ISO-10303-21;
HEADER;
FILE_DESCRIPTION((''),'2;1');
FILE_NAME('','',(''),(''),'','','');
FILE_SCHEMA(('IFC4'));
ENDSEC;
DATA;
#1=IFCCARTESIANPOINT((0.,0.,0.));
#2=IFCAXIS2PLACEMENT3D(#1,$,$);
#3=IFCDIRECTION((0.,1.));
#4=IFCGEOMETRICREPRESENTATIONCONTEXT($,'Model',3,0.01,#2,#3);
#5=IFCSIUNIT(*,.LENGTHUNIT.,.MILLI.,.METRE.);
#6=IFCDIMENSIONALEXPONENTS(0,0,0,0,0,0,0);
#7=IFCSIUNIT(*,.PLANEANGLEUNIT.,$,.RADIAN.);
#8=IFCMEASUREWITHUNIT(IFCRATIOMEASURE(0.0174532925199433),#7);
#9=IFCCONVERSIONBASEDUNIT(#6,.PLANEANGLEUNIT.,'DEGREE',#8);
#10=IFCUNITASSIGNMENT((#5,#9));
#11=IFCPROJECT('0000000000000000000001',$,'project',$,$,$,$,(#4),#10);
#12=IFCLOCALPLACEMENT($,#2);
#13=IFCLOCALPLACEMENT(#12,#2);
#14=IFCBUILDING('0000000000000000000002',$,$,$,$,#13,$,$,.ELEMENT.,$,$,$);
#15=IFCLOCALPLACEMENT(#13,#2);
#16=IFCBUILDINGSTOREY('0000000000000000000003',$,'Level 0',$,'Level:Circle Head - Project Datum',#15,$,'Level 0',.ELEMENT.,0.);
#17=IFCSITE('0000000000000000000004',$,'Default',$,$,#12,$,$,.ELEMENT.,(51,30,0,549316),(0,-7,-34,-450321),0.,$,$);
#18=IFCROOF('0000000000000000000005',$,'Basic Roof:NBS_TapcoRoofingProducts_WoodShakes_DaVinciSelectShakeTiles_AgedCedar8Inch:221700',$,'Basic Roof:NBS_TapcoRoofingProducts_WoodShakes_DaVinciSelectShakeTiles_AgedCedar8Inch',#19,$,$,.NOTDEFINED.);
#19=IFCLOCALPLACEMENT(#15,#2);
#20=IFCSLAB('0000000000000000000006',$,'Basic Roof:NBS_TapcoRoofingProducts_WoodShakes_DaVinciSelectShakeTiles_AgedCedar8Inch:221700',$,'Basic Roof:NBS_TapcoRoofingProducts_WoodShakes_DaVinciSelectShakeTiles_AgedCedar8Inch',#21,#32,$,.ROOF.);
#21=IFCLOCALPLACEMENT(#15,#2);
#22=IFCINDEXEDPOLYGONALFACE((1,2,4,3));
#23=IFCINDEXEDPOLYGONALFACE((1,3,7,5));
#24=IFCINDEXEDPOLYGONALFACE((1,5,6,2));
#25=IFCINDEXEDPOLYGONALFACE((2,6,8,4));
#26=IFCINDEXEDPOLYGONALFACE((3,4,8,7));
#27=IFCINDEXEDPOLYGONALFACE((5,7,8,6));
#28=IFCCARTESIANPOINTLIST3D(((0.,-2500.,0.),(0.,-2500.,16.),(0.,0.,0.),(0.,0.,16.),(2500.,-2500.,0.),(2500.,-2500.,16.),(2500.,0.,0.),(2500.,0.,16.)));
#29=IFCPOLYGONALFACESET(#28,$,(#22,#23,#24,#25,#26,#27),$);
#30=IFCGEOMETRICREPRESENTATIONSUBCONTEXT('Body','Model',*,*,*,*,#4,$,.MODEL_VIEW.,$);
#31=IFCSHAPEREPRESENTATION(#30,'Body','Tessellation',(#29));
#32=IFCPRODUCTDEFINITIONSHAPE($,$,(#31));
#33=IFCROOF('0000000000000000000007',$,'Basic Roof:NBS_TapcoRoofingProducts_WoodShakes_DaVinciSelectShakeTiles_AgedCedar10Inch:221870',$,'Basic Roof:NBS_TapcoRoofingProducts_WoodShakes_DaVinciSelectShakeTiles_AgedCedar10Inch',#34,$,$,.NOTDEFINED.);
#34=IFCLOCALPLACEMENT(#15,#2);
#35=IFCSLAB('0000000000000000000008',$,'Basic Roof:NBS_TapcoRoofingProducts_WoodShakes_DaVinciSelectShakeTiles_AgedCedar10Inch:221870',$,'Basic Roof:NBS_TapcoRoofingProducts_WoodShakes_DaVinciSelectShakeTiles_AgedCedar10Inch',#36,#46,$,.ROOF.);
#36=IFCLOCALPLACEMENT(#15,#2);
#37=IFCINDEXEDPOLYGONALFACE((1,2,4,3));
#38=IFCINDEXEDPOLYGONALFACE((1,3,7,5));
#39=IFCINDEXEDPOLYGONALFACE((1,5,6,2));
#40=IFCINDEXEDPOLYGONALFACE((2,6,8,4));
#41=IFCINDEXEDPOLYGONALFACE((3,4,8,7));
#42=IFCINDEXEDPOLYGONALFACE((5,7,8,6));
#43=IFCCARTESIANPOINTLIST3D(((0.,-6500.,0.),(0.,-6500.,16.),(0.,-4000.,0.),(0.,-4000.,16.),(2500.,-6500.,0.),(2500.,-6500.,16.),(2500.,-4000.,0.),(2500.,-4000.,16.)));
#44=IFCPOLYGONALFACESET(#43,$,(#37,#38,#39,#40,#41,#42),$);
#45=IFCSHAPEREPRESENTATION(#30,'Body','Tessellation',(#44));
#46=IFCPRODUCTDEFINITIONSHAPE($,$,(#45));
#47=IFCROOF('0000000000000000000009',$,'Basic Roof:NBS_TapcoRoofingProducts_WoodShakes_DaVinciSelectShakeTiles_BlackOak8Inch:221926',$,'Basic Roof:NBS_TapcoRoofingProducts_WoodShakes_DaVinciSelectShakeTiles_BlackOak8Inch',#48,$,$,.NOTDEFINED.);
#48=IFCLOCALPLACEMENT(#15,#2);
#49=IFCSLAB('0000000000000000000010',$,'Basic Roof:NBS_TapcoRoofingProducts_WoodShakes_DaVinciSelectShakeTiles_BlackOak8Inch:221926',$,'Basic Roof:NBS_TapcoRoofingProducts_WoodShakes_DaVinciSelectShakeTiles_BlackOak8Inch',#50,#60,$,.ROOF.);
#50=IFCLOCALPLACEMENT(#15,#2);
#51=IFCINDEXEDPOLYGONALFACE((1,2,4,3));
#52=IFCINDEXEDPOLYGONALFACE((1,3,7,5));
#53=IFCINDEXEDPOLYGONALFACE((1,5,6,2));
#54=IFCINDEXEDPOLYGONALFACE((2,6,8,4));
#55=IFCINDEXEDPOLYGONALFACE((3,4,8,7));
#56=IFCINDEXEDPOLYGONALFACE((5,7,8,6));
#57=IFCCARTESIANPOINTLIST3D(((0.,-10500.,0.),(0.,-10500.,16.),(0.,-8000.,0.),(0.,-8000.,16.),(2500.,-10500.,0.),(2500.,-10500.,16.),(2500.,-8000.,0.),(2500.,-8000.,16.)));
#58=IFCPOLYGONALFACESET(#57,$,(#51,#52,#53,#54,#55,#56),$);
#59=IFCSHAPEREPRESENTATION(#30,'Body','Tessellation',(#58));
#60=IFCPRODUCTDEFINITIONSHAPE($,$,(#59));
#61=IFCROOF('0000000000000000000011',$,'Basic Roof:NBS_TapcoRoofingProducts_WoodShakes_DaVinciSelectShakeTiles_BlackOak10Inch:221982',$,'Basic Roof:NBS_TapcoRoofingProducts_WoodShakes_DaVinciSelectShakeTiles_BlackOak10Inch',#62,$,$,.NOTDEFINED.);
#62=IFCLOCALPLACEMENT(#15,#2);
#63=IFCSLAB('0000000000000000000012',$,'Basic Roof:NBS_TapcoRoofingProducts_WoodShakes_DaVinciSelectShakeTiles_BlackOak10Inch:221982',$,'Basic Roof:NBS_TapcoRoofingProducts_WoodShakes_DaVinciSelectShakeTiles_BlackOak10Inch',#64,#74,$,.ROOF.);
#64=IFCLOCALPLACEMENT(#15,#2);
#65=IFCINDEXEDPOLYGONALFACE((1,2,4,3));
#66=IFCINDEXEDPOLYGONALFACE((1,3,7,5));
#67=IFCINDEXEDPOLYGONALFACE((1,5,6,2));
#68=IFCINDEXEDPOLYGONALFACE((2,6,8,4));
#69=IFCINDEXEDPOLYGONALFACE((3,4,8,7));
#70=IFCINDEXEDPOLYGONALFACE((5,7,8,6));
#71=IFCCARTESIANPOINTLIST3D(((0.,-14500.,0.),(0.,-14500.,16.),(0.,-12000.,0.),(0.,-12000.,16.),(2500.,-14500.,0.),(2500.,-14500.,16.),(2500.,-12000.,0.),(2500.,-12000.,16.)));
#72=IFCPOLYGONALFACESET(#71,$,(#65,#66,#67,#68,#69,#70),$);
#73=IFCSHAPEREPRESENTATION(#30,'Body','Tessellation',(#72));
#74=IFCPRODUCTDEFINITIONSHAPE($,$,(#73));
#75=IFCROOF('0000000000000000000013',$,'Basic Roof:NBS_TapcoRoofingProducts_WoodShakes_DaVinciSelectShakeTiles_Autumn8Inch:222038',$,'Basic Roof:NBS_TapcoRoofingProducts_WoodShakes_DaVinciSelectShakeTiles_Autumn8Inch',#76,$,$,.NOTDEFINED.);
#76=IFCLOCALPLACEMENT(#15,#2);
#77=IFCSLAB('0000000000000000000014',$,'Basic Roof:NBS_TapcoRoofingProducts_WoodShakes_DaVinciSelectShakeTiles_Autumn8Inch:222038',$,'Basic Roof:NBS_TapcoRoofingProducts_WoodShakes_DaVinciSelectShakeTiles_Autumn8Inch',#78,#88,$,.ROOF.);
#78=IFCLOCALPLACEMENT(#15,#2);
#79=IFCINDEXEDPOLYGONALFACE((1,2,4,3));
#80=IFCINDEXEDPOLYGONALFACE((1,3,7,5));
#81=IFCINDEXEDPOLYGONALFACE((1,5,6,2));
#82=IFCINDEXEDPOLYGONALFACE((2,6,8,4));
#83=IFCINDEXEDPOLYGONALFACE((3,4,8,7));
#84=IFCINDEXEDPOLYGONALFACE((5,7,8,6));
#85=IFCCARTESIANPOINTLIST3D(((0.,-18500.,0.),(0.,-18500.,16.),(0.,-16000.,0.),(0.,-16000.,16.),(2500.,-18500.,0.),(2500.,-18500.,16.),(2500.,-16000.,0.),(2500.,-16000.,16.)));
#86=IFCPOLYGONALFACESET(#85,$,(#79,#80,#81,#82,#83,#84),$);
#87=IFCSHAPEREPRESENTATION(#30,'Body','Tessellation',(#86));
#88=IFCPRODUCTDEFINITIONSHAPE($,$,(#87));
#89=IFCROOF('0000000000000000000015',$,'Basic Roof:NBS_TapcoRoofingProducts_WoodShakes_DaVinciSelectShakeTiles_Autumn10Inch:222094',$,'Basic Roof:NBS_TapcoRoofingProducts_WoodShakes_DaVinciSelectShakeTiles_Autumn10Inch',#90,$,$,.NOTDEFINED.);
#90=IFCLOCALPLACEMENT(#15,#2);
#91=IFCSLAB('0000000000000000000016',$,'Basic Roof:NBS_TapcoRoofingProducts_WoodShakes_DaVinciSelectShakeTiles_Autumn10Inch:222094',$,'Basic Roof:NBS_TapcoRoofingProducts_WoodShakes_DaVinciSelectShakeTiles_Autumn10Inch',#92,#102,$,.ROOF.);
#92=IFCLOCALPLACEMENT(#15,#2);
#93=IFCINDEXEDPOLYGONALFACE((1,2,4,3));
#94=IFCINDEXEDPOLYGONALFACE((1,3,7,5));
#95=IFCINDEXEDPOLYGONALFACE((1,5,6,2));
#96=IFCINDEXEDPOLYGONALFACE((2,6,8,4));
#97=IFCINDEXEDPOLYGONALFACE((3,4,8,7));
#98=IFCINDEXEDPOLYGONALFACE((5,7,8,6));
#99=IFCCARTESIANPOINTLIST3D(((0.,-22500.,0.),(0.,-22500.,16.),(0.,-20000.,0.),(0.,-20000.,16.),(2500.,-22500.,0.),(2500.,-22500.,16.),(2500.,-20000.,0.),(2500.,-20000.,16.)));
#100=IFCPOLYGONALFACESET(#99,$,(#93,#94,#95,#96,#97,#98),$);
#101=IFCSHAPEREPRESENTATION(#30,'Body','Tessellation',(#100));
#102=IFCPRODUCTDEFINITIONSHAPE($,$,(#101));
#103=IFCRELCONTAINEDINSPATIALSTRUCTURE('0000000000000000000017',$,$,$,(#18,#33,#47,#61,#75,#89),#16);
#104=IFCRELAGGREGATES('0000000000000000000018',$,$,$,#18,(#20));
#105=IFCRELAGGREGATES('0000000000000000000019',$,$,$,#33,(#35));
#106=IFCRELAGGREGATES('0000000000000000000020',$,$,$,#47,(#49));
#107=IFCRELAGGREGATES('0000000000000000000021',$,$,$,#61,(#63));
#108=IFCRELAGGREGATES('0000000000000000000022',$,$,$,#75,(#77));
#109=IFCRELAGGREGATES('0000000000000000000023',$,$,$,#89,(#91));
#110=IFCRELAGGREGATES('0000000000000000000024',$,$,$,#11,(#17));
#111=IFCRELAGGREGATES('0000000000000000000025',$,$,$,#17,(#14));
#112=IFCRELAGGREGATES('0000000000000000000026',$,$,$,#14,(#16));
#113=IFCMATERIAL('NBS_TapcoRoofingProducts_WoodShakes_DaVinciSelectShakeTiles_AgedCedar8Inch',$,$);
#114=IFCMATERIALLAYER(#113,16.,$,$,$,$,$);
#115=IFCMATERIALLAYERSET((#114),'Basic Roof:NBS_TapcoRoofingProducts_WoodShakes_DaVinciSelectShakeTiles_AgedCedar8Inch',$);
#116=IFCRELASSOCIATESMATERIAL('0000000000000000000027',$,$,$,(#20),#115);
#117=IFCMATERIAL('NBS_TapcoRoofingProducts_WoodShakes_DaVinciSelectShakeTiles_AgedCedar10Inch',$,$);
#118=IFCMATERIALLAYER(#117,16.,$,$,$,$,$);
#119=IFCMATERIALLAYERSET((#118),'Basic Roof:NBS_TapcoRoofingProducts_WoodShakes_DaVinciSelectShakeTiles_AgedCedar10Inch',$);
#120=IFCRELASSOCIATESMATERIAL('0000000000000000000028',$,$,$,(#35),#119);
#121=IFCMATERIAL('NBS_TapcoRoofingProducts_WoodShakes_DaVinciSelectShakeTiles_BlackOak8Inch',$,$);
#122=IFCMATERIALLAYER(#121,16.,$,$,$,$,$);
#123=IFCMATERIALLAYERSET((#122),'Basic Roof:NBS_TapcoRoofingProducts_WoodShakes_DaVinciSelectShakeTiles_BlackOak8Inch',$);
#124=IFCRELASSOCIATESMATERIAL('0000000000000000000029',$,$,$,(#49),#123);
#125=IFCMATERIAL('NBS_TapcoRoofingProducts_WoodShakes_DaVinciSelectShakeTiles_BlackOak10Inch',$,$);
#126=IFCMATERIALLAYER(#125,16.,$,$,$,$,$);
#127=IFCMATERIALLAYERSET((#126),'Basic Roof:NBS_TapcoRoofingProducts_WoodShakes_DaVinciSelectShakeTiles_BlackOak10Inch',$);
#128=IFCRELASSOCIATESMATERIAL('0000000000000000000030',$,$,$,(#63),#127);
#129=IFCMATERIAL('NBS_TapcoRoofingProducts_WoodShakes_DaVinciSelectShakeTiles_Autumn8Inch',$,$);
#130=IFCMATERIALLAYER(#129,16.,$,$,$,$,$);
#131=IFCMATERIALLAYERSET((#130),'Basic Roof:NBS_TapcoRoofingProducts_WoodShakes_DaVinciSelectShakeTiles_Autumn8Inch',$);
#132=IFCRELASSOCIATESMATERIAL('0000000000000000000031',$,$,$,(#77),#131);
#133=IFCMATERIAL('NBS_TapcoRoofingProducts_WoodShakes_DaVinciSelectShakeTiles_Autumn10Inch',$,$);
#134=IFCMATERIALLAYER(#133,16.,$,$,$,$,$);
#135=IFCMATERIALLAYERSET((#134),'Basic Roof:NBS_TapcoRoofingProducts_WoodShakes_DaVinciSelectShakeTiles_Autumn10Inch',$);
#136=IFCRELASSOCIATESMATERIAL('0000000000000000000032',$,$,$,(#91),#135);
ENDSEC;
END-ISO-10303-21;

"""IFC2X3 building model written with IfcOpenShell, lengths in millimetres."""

from ifc_helpers import new_model, entity, si_unit, converted_unit, direction, frame, frame_2d, origin, place, context, subcontext, project, spatial, rectangle, extrude, material, layer, layer_set, element, aggregate, save


model = new_model("IFC2X3")

# Units and contexts
model_context = context("Model", 3, precision=0.01, world=origin(), true_north=direction((0.0, 1.0)))
body_context = subcontext(model_context, "Body", "Model", "MODEL_VIEW")
ifc_project = project(units=[si_unit("LENGTHUNIT", "METRE", prefix="MILLI"), converted_unit("PLANEANGLEUNIT", "DEGREE", entity("IfcRatioMeasure", 0.0174532925199433), si_unit("PLANEANGLEUNIT", "RADIAN"), dimensions=[0, 0, 0, 0, 0, 0, 0])], contexts=[model_context])

# Site, building, storey
site_placement = place(None, origin())
site = spatial("IfcSite", under=ifc_project, at=site_placement, Name="Default", CompositionType="ELEMENT", RefLatitude=(51, 30, 0, 549316), RefLongitude=(0, -7, -34, -450321), RefElevation=0.0)
building_placement = place(site_placement, origin())
building = spatial("IfcBuilding", under=site, at=building_placement, CompositionType="ELEMENT")
storey_placement = place(building_placement, origin())
storey = spatial("IfcBuildingStorey", under=building, at=storey_placement, Name="Level 0", ObjectType="Level:Circle Head - Project Datum", LongName="Level 0", CompositionType="ELEMENT", Elevation=0.0)

# Roofs, slabs
roof_1_placement = place(storey_placement, origin())
roof_1 = element("IfcRoof", 1, at=roof_1_placement, inside=storey, Name="Basic Roof:NBS_TapcoRoofingProducts_WoodShakes_DaVinciSelectShakeTiles_AgedCedar8Inch:221700", ObjectType="Basic Roof:NBS_TapcoRoofingProducts_WoodShakes_DaVinciSelectShakeTiles_AgedCedar8Inch", ShapeType="NOTDEFINED")
ifc_material_1 = material(Name="NBS_TapcoRoofingProducts_WoodShakes_DaVinciSelectShakeTiles_AgedCedar8Inch")
ifc_layer_1 = layer(ifc_material_1, 16.0)
ifc_layer_set_1 = layer_set([ifc_layer_1], Name="Basic Roof:NBS_TapcoRoofingProducts_WoodShakes_DaVinciSelectShakeTiles_AgedCedar8Inch")
slab_1_placement = place(storey_placement, origin())
slab_1 = element("IfcSlab", 2, at=slab_1_placement, material=ifc_layer_set_1, Name="Basic Roof:NBS_TapcoRoofingProducts_WoodShakes_DaVinciSelectShakeTiles_AgedCedar8Inch:221700", ObjectType="Basic Roof:NBS_TapcoRoofingProducts_WoodShakes_DaVinciSelectShakeTiles_AgedCedar8Inch", PredefinedType="ROOF", context=body_context, shape_type="SweptSolid", body=[
    extrude(rectangle(XDim=2500.0, YDim=2500.0, at=frame_2d((0.0, 0.0), x_axis=(0.0, 1.0))), frame((1250.0, -1250.0, 0.0)), (0.0, 0.0, 1.0), 16.0),
])
aggregate(roof_1, [slab_1])
roof_2_placement = place(storey_placement, frame((0.0, -6500.0, 0.0)))
roof_2 = element("IfcRoof", 3, at=roof_2_placement, inside=storey, Name="Basic Roof:NBS_TapcoRoofingProducts_WoodShakes_DaVinciSelectShakeTiles_AgedCedar10Inch:221870", ObjectType="Basic Roof:NBS_TapcoRoofingProducts_WoodShakes_DaVinciSelectShakeTiles_AgedCedar10Inch", ShapeType="NOTDEFINED")
ifc_material_2 = material(Name="NBS_TapcoRoofingProducts_WoodShakes_DaVinciSelectShakeTiles_AgedCedar10Inch")
ifc_layer_2 = layer(ifc_material_2, 16.0)
ifc_layer_set_2 = layer_set([ifc_layer_2], Name="Basic Roof:NBS_TapcoRoofingProducts_WoodShakes_DaVinciSelectShakeTiles_AgedCedar10Inch")
slab_2_placement = place(roof_2_placement, origin())
slab_2 = element("IfcSlab", 4, at=slab_2_placement, material=ifc_layer_set_2, Name="Basic Roof:NBS_TapcoRoofingProducts_WoodShakes_DaVinciSelectShakeTiles_AgedCedar10Inch:221870", ObjectType="Basic Roof:NBS_TapcoRoofingProducts_WoodShakes_DaVinciSelectShakeTiles_AgedCedar10Inch", PredefinedType="ROOF", context=body_context, shape_type="SweptSolid", body=[
    extrude(rectangle(XDim=2500.0, YDim=2500.0, at=frame_2d((0.0, 0.0), x_axis=(0.0, 1.0))), frame((1250.0, 1250.0, 0.0)), (0.0, 0.0, 1.0), 16.0),
])
aggregate(roof_2, [slab_2])
roof_3_placement = place(storey_placement, frame((0.0, -10500.0, 0.0)))
roof_3 = element("IfcRoof", 5, at=roof_3_placement, inside=storey, Name="Basic Roof:NBS_TapcoRoofingProducts_WoodShakes_DaVinciSelectShakeTiles_BlackOak8Inch:221926", ObjectType="Basic Roof:NBS_TapcoRoofingProducts_WoodShakes_DaVinciSelectShakeTiles_BlackOak8Inch", ShapeType="NOTDEFINED")
ifc_material_3 = material(Name="NBS_TapcoRoofingProducts_WoodShakes_DaVinciSelectShakeTiles_BlackOak8Inch")
ifc_layer_3 = layer(ifc_material_3, 16.0)
ifc_layer_set_3 = layer_set([ifc_layer_3], Name="Basic Roof:NBS_TapcoRoofingProducts_WoodShakes_DaVinciSelectShakeTiles_BlackOak8Inch")
slab_3_placement = place(roof_3_placement, origin())
slab_3 = element("IfcSlab", 6, at=slab_3_placement, material=ifc_layer_set_3, Name="Basic Roof:NBS_TapcoRoofingProducts_WoodShakes_DaVinciSelectShakeTiles_BlackOak8Inch:221926", ObjectType="Basic Roof:NBS_TapcoRoofingProducts_WoodShakes_DaVinciSelectShakeTiles_BlackOak8Inch", PredefinedType="ROOF", context=body_context, shape_type="SweptSolid", body=[
    extrude(rectangle(XDim=2500.0, YDim=2500.0, at=frame_2d((0.0, 0.0), x_axis=(0.0, 1.0))), frame((1250.0, 1250.0, 0.0)), (0.0, 0.0, 1.0), 16.0),
])
aggregate(roof_3, [slab_3])
roof_4_placement = place(storey_placement, frame((0.0, -14500.0, 0.0)))
roof_4 = element("IfcRoof", 7, at=roof_4_placement, inside=storey, Name="Basic Roof:NBS_TapcoRoofingProducts_WoodShakes_DaVinciSelectShakeTiles_BlackOak10Inch:221982", ObjectType="Basic Roof:NBS_TapcoRoofingProducts_WoodShakes_DaVinciSelectShakeTiles_BlackOak10Inch", ShapeType="NOTDEFINED")
ifc_material_4 = material(Name="NBS_TapcoRoofingProducts_WoodShakes_DaVinciSelectShakeTiles_BlackOak10Inch")
ifc_layer_4 = layer(ifc_material_4, 16.0)
ifc_layer_set_4 = layer_set([ifc_layer_4], Name="Basic Roof:NBS_TapcoRoofingProducts_WoodShakes_DaVinciSelectShakeTiles_BlackOak10Inch")
slab_4_placement = place(roof_4_placement, origin())
slab_4 = element("IfcSlab", 8, at=slab_4_placement, material=ifc_layer_set_4, Name="Basic Roof:NBS_TapcoRoofingProducts_WoodShakes_DaVinciSelectShakeTiles_BlackOak10Inch:221982", ObjectType="Basic Roof:NBS_TapcoRoofingProducts_WoodShakes_DaVinciSelectShakeTiles_BlackOak10Inch", PredefinedType="ROOF", context=body_context, shape_type="SweptSolid", body=[
    extrude(rectangle(XDim=2500.0, YDim=2500.0, at=frame_2d((0.0, 0.0), x_axis=(0.0, 1.0))), frame((1250.0, 1250.0, 0.0)), (0.0, 0.0, 1.0), 16.0),
])
aggregate(roof_4, [slab_4])
roof_5_placement = place(storey_placement, frame((0.0, -18500.0, 0.0)))
roof_5 = element("IfcRoof", 9, at=roof_5_placement, inside=storey, Name="Basic Roof:NBS_TapcoRoofingProducts_WoodShakes_DaVinciSelectShakeTiles_Autumn8Inch:222038", ObjectType="Basic Roof:NBS_TapcoRoofingProducts_WoodShakes_DaVinciSelectShakeTiles_Autumn8Inch", ShapeType="NOTDEFINED")
ifc_material_5 = material(Name="NBS_TapcoRoofingProducts_WoodShakes_DaVinciSelectShakeTiles_Autumn8Inch")
ifc_layer_5 = layer(ifc_material_5, 16.0)
ifc_layer_set_5 = layer_set([ifc_layer_5], Name="Basic Roof:NBS_TapcoRoofingProducts_WoodShakes_DaVinciSelectShakeTiles_Autumn8Inch")
slab_5_placement = place(roof_5_placement, origin())
slab_5 = element("IfcSlab", 10, at=slab_5_placement, material=ifc_layer_set_5, Name="Basic Roof:NBS_TapcoRoofingProducts_WoodShakes_DaVinciSelectShakeTiles_Autumn8Inch:222038", ObjectType="Basic Roof:NBS_TapcoRoofingProducts_WoodShakes_DaVinciSelectShakeTiles_Autumn8Inch", PredefinedType="ROOF", context=body_context, shape_type="SweptSolid", body=[
    extrude(rectangle(XDim=2500.0, YDim=2500.0, at=frame_2d((0.0, 0.0), x_axis=(0.0, 1.0))), frame((1250.0, 1250.0, 0.0)), (0.0, 0.0, 1.0), 16.0),
])
aggregate(roof_5, [slab_5])
roof_6_placement = place(storey_placement, frame((0.0, -22500.0, 0.0)))
roof_6 = element("IfcRoof", 11, at=roof_6_placement, inside=storey, Name="Basic Roof:NBS_TapcoRoofingProducts_WoodShakes_DaVinciSelectShakeTiles_Autumn10Inch:222094", ObjectType="Basic Roof:NBS_TapcoRoofingProducts_WoodShakes_DaVinciSelectShakeTiles_Autumn10Inch", ShapeType="NOTDEFINED")
ifc_material_6 = material(Name="NBS_TapcoRoofingProducts_WoodShakes_DaVinciSelectShakeTiles_Autumn10Inch")
ifc_layer_6 = layer(ifc_material_6, 16.0)
ifc_layer_set_6 = layer_set([ifc_layer_6], Name="Basic Roof:NBS_TapcoRoofingProducts_WoodShakes_DaVinciSelectShakeTiles_Autumn10Inch")
slab_6_placement = place(roof_6_placement, origin())
slab_6 = element("IfcSlab", 12, at=slab_6_placement, material=ifc_layer_set_6, Name="Basic Roof:NBS_TapcoRoofingProducts_WoodShakes_DaVinciSelectShakeTiles_Autumn10Inch:222094", ObjectType="Basic Roof:NBS_TapcoRoofingProducts_WoodShakes_DaVinciSelectShakeTiles_Autumn10Inch", PredefinedType="ROOF", context=body_context, shape_type="SweptSolid", body=[
    extrude(rectangle(XDim=2500.0, YDim=2500.0, at=frame_2d((0.0, 0.0), x_axis=(0.0, 1.0))), frame((1250.0, 1250.0, 0.0)), (0.0, 0.0, 1.0), 16.0),
])
aggregate(roof_6, [slab_6])

save(model, "model.ifc")
